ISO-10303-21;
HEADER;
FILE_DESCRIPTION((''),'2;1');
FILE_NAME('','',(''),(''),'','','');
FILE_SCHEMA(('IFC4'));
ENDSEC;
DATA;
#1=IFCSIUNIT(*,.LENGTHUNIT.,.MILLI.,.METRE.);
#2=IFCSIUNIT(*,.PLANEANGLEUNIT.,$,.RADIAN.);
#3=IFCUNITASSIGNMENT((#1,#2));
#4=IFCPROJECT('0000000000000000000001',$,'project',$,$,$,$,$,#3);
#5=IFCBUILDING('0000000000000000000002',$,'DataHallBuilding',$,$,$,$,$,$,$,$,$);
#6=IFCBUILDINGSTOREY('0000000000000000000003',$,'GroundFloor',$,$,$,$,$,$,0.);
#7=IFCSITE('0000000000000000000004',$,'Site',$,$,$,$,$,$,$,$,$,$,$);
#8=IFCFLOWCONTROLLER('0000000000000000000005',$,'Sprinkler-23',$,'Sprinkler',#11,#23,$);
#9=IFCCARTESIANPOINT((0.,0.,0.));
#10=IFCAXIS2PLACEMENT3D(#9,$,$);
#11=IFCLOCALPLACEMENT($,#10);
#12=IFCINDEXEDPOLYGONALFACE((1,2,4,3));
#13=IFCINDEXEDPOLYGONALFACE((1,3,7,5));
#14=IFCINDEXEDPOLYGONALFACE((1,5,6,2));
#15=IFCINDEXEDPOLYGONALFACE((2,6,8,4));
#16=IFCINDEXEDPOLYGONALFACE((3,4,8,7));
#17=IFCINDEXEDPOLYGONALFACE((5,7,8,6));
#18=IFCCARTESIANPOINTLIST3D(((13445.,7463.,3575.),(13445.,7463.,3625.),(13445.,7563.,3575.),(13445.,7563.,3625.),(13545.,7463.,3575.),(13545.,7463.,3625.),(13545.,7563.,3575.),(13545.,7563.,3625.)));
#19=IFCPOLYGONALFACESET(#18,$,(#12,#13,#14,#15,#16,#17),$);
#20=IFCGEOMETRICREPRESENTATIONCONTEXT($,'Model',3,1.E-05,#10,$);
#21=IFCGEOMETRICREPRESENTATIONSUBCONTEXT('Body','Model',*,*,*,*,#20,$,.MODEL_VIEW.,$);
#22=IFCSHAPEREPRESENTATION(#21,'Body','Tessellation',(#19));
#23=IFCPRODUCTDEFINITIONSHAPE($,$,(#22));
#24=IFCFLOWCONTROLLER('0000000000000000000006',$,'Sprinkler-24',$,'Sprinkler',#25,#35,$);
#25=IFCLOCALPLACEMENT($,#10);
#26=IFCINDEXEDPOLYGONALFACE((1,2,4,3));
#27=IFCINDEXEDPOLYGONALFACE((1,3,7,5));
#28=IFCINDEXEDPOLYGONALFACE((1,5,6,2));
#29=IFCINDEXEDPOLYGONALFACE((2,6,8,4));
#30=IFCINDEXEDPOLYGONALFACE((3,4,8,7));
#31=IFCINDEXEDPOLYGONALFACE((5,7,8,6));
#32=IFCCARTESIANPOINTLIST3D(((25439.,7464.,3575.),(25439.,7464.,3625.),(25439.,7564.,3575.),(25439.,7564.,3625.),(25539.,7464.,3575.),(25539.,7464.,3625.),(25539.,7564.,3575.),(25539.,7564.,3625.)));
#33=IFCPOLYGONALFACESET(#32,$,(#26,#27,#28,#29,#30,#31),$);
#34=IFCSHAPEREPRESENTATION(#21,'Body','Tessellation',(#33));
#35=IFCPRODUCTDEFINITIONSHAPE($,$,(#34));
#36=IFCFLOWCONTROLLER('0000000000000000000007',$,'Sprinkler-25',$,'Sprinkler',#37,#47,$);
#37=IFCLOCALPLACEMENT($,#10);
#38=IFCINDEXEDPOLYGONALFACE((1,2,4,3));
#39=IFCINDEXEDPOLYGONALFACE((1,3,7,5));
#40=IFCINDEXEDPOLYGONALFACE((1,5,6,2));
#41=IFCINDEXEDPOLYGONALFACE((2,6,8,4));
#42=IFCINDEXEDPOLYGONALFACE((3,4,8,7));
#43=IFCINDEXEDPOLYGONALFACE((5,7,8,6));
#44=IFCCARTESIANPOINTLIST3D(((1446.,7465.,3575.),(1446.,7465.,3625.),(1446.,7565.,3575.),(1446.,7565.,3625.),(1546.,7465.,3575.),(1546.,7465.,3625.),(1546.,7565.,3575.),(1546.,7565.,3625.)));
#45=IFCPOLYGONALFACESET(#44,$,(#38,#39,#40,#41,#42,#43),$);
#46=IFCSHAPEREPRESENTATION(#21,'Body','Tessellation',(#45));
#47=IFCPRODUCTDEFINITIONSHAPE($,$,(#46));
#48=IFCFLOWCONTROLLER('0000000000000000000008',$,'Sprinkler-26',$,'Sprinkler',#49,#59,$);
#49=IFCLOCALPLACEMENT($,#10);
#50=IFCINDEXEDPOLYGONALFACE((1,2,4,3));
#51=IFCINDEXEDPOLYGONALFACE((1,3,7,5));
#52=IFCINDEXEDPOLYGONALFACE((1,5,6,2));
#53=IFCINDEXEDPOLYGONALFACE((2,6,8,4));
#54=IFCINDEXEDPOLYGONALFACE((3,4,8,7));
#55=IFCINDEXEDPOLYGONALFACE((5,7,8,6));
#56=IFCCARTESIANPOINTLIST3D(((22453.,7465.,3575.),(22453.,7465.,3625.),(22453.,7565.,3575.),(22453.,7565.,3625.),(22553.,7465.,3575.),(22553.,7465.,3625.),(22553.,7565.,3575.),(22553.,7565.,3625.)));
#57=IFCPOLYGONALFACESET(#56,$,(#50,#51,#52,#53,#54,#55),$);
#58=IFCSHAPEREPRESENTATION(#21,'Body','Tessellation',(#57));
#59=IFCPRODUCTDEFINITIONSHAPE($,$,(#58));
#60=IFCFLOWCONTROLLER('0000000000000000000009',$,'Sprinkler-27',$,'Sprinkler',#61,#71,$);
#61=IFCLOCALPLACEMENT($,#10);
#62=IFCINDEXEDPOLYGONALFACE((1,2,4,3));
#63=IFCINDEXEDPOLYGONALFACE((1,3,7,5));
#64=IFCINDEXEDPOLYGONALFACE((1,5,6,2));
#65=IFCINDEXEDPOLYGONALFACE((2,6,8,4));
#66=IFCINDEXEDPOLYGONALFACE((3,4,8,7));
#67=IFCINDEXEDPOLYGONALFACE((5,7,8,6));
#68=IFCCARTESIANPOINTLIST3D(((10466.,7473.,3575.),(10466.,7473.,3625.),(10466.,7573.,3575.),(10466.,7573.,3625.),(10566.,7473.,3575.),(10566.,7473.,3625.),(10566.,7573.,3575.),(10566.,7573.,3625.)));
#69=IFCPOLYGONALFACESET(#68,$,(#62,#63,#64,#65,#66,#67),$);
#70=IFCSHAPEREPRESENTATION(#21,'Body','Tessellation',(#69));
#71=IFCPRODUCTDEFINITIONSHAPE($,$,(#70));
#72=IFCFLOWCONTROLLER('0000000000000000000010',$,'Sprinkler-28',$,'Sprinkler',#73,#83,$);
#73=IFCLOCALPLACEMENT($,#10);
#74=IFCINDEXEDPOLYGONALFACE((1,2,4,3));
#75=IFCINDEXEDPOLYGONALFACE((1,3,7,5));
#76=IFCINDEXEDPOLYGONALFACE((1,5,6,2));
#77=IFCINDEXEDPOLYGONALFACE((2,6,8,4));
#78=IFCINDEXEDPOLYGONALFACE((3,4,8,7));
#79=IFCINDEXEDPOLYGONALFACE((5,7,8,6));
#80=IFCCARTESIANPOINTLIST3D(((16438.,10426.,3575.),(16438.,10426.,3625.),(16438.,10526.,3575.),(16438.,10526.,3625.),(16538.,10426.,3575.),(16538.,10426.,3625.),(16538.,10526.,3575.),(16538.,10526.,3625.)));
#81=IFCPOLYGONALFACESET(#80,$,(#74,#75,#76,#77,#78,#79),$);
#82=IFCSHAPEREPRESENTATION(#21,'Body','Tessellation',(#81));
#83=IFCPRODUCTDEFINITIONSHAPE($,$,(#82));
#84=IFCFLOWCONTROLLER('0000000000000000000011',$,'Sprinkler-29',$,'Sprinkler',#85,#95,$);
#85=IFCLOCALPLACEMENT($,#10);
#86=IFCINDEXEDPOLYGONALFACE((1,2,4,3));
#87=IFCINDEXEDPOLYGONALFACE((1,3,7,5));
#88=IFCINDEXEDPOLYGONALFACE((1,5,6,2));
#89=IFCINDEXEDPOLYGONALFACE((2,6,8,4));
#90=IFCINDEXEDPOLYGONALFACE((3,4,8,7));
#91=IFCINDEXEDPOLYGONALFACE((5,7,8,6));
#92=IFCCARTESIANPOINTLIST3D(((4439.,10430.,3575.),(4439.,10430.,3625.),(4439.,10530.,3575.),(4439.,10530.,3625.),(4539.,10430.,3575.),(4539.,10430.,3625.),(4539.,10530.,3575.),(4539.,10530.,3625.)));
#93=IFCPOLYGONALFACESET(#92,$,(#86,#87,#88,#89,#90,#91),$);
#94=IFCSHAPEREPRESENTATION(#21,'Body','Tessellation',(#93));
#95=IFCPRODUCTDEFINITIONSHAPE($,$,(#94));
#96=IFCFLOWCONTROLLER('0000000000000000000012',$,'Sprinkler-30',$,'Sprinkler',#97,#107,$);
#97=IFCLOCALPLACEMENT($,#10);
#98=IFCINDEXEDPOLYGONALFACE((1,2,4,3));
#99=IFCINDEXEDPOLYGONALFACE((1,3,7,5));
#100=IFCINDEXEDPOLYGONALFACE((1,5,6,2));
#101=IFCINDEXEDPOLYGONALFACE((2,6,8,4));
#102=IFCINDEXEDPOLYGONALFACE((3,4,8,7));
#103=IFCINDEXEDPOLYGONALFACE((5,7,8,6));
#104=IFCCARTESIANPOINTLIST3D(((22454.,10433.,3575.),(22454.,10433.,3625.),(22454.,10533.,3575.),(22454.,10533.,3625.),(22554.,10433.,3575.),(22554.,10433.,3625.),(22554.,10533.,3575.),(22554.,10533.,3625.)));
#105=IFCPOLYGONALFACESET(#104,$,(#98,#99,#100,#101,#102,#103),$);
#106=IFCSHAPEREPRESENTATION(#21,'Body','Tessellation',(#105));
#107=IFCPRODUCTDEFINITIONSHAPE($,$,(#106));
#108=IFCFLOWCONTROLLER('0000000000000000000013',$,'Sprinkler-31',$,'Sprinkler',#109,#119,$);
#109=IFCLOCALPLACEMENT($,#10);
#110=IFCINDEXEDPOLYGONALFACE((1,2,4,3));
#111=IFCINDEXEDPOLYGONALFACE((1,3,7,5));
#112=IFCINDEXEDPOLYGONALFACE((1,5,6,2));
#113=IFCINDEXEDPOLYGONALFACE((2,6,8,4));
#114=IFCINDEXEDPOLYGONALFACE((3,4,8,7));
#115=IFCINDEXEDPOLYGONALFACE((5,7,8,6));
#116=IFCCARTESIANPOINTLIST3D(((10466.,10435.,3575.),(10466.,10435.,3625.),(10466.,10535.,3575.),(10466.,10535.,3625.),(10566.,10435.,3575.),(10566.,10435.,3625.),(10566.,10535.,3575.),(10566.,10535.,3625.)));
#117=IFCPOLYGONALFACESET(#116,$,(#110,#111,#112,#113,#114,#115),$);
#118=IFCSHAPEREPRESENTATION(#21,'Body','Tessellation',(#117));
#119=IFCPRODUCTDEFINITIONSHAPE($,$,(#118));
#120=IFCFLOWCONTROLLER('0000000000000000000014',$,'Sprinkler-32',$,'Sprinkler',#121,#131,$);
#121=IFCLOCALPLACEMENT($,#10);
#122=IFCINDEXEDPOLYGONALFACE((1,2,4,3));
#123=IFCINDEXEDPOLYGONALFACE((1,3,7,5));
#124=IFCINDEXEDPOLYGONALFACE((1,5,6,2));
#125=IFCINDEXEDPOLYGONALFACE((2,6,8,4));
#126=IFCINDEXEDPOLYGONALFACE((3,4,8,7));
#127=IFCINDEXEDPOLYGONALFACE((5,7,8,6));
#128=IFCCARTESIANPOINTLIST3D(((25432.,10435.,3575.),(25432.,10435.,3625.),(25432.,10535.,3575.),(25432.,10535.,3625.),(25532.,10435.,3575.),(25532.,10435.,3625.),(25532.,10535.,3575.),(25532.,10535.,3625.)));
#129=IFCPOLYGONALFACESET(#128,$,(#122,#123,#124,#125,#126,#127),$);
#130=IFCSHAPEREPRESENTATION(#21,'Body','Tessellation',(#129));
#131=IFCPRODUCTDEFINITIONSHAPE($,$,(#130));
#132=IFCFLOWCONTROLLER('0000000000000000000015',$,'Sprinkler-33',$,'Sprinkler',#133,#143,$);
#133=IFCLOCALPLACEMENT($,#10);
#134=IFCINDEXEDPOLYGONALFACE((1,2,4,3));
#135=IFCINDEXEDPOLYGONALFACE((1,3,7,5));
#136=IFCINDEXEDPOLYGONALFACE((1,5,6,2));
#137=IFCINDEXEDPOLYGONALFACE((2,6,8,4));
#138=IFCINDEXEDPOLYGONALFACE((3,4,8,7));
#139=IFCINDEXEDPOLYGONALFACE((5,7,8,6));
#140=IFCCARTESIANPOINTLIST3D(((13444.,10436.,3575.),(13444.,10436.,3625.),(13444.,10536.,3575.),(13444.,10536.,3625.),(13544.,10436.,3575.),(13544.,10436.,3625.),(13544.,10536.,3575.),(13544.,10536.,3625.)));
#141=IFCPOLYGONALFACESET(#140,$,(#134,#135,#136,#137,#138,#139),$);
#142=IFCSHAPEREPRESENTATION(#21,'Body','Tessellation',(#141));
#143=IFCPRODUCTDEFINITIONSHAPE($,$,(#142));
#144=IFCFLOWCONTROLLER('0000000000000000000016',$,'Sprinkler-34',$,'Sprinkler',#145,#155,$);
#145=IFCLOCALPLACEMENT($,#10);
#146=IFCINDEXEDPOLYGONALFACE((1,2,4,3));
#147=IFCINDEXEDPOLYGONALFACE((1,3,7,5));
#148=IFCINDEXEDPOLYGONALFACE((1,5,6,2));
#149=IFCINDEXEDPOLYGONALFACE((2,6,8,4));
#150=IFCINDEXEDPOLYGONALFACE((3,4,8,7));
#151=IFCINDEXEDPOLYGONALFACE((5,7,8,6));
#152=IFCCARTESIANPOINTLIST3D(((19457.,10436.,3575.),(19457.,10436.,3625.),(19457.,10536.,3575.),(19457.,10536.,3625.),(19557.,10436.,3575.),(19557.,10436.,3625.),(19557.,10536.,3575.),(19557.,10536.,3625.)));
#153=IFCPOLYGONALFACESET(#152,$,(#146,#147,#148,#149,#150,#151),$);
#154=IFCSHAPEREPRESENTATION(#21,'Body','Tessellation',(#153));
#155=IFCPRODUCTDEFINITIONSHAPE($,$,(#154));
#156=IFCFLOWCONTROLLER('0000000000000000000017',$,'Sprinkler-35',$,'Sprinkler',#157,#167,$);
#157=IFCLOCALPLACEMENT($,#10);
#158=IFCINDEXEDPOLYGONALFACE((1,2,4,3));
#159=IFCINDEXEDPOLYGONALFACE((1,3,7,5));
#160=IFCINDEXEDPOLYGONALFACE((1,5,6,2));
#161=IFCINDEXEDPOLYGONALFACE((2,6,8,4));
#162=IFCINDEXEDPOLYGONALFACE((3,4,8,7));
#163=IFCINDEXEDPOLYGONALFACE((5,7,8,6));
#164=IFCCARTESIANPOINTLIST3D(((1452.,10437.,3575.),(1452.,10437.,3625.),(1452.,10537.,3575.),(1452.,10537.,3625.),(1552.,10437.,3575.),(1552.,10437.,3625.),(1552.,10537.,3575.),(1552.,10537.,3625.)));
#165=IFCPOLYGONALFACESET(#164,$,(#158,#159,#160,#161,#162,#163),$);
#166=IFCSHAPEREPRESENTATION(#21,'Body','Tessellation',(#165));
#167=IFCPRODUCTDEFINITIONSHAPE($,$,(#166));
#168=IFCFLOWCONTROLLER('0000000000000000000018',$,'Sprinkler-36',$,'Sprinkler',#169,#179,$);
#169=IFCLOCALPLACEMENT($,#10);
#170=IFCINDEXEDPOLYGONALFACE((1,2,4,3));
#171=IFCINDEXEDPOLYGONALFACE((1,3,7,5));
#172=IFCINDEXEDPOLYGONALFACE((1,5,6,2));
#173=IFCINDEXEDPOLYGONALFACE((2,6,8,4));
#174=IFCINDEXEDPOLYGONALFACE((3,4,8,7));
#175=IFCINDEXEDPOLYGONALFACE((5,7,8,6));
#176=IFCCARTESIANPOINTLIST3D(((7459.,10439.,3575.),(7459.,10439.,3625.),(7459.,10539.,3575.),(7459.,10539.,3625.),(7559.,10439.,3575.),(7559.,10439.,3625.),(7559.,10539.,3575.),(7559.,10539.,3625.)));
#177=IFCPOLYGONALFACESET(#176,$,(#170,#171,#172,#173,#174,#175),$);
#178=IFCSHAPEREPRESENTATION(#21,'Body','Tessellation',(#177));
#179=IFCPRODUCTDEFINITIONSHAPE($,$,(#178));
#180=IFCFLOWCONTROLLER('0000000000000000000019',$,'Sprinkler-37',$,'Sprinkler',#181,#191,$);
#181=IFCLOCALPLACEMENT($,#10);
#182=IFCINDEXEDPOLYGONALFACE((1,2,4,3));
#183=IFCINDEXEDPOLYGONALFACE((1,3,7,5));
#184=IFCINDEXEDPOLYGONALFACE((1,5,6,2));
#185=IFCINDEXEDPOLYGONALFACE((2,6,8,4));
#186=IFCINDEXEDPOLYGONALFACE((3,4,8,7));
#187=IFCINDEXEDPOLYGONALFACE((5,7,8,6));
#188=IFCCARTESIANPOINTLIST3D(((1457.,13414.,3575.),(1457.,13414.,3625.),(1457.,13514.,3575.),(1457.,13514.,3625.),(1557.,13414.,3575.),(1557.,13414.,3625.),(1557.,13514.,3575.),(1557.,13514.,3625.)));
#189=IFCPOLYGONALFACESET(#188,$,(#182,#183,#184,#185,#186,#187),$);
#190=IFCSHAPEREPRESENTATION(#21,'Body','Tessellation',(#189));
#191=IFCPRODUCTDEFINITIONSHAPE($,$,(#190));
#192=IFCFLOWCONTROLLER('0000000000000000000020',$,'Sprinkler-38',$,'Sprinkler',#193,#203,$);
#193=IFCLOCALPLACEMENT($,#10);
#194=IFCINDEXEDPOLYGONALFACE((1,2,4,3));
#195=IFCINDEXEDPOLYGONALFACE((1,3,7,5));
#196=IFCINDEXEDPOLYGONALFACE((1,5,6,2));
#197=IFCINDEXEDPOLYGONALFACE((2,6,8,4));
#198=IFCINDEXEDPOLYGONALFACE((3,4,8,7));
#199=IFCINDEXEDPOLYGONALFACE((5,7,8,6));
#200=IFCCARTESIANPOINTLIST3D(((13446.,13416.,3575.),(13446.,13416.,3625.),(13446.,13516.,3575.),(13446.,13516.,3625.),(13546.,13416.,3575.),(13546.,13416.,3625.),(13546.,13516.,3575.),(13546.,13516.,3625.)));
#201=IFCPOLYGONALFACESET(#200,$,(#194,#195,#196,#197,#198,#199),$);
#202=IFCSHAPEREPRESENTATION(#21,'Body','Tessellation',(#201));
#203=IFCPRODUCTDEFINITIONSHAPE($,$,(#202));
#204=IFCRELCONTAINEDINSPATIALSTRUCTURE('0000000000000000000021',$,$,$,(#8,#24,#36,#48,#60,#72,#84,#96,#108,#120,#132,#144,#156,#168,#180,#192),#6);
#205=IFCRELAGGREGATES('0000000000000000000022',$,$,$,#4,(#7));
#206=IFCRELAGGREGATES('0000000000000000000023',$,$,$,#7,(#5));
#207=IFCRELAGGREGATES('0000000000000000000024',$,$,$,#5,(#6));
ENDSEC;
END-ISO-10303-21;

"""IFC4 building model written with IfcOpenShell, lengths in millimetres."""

from ifc_helpers import new_model, si_unit, frame, origin, place, context, subcontext, project, spatial, rectangle, extrude, element, save


model = new_model("IFC4")

# Units and contexts
model_context = context("Model", 3, precision=1e-05, world=origin())
body_context = subcontext(model_context, "Body", "Model", "MODEL_VIEW")
ifc_project = project(units=[si_unit("LENGTHUNIT", "METRE", prefix="MILLI"), si_unit("PLANEANGLEUNIT", "RADIAN")])

# Site, building, storey
site = spatial("IfcSite", under=ifc_project, Name="Site")
building = spatial("IfcBuilding", under=site, Name="DataHallBuilding")
storey = spatial("IfcBuildingStorey", under=building, Name="GroundFloor", Elevation=0.0)

# Flow controllers
flow_controller_1_placement = place(None, origin())
element("IfcFlowController", 1, at=flow_controller_1_placement, inside=storey, Name="Sprinkler-23", ObjectType="Sprinkler", context=body_context, shape_type="SweptSolid", body=[
    extrude(rectangle(XDim=100.0, YDim=100.0), frame((13495.0, 7513.0, 3575.0), z_axis=(0.0, 0.0, 1.0), x_axis=(1.0, 0.0, 0.0)), (0.0, 0.0, 1.0), 50.0),
])
flow_controller_2_placement = place(None, origin())
element("IfcFlowController", 2, at=flow_controller_2_placement, inside=storey, Name="Sprinkler-24", ObjectType="Sprinkler", context=body_context, shape_type="SweptSolid", body=[
    extrude(rectangle(XDim=100.0, YDim=100.0), frame((25489.0, 7514.0, 3575.0), z_axis=(0.0, 0.0, 1.0), x_axis=(1.0, 0.0, 0.0)), (0.0, 0.0, 1.0), 50.0),
])
flow_controller_3_placement = place(None, origin())
element("IfcFlowController", 3, at=flow_controller_3_placement, inside=storey, Name="Sprinkler-25", ObjectType="Sprinkler", context=body_context, shape_type="SweptSolid", body=[
    extrude(rectangle(XDim=100.0, YDim=100.0), frame((1496.0, 7515.0, 3575.0), z_axis=(0.0, 0.0, 1.0), x_axis=(1.0, 0.0, 0.0)), (0.0, 0.0, 1.0), 50.0),
])
flow_controller_4_placement = place(None, origin())
element("IfcFlowController", 4, at=flow_controller_4_placement, inside=storey, Name="Sprinkler-26", ObjectType="Sprinkler", context=body_context, shape_type="SweptSolid", body=[
    extrude(rectangle(XDim=100.0, YDim=100.0), frame((22503.0, 7515.0, 3575.0), z_axis=(0.0, 0.0, 1.0), x_axis=(1.0, 0.0, 0.0)), (0.0, 0.0, 1.0), 50.0),
])
flow_controller_5_placement = place(None, origin())
element("IfcFlowController", 5, at=flow_controller_5_placement, inside=storey, Name="Sprinkler-27", ObjectType="Sprinkler", context=body_context, shape_type="SweptSolid", body=[
    extrude(rectangle(XDim=100.0, YDim=100.0), frame((10516.0, 7523.0, 3575.0), z_axis=(0.0, 0.0, 1.0), x_axis=(1.0, 0.0, 0.0)), (0.0, 0.0, 1.0), 50.0),
])
flow_controller_6_placement = place(None, origin())
element("IfcFlowController", 6, at=flow_controller_6_placement, inside=storey, Name="Sprinkler-28", ObjectType="Sprinkler", context=body_context, shape_type="SweptSolid", body=[
    extrude(rectangle(XDim=100.0, YDim=100.0), frame((16488.0, 10476.0, 3575.0), z_axis=(0.0, 0.0, 1.0), x_axis=(1.0, 0.0, 0.0)), (0.0, 0.0, 1.0), 50.0),
])
flow_controller_7_placement = place(None, origin())
element("IfcFlowController", 7, at=flow_controller_7_placement, inside=storey, Name="Sprinkler-29", ObjectType="Sprinkler", context=body_context, shape_type="SweptSolid", body=[
    extrude(rectangle(XDim=100.0, YDim=100.0), frame((4489.0, 10480.0, 3575.0), z_axis=(0.0, 0.0, 1.0), x_axis=(1.0, 0.0, 0.0)), (0.0, 0.0, 1.0), 50.0),
])
flow_controller_8_placement = place(None, origin())
element("IfcFlowController", 8, at=flow_controller_8_placement, inside=storey, Name="Sprinkler-30", ObjectType="Sprinkler", context=body_context, shape_type="SweptSolid", body=[
    extrude(rectangle(XDim=100.0, YDim=100.0), frame((22504.0, 10483.0, 3575.0), z_axis=(0.0, 0.0, 1.0), x_axis=(1.0, 0.0, 0.0)), (0.0, 0.0, 1.0), 50.0),
])
flow_controller_9_placement = place(None, origin())
element("IfcFlowController", 9, at=flow_controller_9_placement, inside=storey, Name="Sprinkler-31", ObjectType="Sprinkler", context=body_context, shape_type="SweptSolid", body=[
    extrude(rectangle(XDim=100.0, YDim=100.0), frame((10516.0, 10485.0, 3575.0), z_axis=(0.0, 0.0, 1.0), x_axis=(1.0, 0.0, 0.0)), (0.0, 0.0, 1.0), 50.0),
])
flow_controller_10_placement = place(None, origin())
element("IfcFlowController", 10, at=flow_controller_10_placement, inside=storey, Name="Sprinkler-32", ObjectType="Sprinkler", context=body_context, shape_type="SweptSolid", body=[
    extrude(rectangle(XDim=100.0, YDim=100.0), frame((25482.0, 10485.0, 3575.0), z_axis=(0.0, 0.0, 1.0), x_axis=(1.0, 0.0, 0.0)), (0.0, 0.0, 1.0), 50.0),
])
flow_controller_11_placement = place(None, origin())
element("IfcFlowController", 11, at=flow_controller_11_placement, inside=storey, Name="Sprinkler-33", ObjectType="Sprinkler", context=body_context, shape_type="SweptSolid", body=[
    extrude(rectangle(XDim=100.0, YDim=100.0), frame((13494.0, 10486.0, 3575.0), z_axis=(0.0, 0.0, 1.0), x_axis=(1.0, 0.0, 0.0)), (0.0, 0.0, 1.0), 50.0),
])
flow_controller_12_placement = place(None, origin())
element("IfcFlowController", 12, at=flow_controller_12_placement, inside=storey, Name="Sprinkler-34", ObjectType="Sprinkler", context=body_context, shape_type="SweptSolid", body=[
    extrude(rectangle(XDim=100.0, YDim=100.0), frame((19507.0, 10486.0, 3575.0), z_axis=(0.0, 0.0, 1.0), x_axis=(1.0, 0.0, 0.0)), (0.0, 0.0, 1.0), 50.0),
])
flow_controller_13_placement = place(None, origin())
element("IfcFlowController", 13, at=flow_controller_13_placement, inside=storey, Name="Sprinkler-35", ObjectType="Sprinkler", context=body_context, shape_type="SweptSolid", body=[
    extrude(rectangle(XDim=100.0, YDim=100.0), frame((1502.0, 10487.0, 3575.0), z_axis=(0.0, 0.0, 1.0), x_axis=(1.0, 0.0, 0.0)), (0.0, 0.0, 1.0), 50.0),
])
flow_controller_14_placement = place(None, origin())
element("IfcFlowController", 14, at=flow_controller_14_placement, inside=storey, Name="Sprinkler-36", ObjectType="Sprinkler", context=body_context, shape_type="SweptSolid", body=[
    extrude(rectangle(XDim=100.0, YDim=100.0), frame((7509.0, 10489.0, 3575.0), z_axis=(0.0, 0.0, 1.0), x_axis=(1.0, 0.0, 0.0)), (0.0, 0.0, 1.0), 50.0),
])
flow_controller_15_placement = place(None, origin())
element("IfcFlowController", 15, at=flow_controller_15_placement, inside=storey, Name="Sprinkler-37", ObjectType="Sprinkler", context=body_context, shape_type="SweptSolid", body=[
    extrude(rectangle(XDim=100.0, YDim=100.0), frame((1507.0, 13464.0, 3575.0), z_axis=(0.0, 0.0, 1.0), x_axis=(1.0, 0.0, 0.0)), (0.0, 0.0, 1.0), 50.0),
])
flow_controller_16_placement = place(None, origin())
element("IfcFlowController", 16, at=flow_controller_16_placement, inside=storey, Name="Sprinkler-38", ObjectType="Sprinkler", context=body_context, shape_type="SweptSolid", body=[
    extrude(rectangle(XDim=100.0, YDim=100.0), frame((13496.0, 13466.0, 3575.0), z_axis=(0.0, 0.0, 1.0), x_axis=(1.0, 0.0, 0.0)), (0.0, 0.0, 1.0), 50.0),
])

save(model, "model.ifc")
